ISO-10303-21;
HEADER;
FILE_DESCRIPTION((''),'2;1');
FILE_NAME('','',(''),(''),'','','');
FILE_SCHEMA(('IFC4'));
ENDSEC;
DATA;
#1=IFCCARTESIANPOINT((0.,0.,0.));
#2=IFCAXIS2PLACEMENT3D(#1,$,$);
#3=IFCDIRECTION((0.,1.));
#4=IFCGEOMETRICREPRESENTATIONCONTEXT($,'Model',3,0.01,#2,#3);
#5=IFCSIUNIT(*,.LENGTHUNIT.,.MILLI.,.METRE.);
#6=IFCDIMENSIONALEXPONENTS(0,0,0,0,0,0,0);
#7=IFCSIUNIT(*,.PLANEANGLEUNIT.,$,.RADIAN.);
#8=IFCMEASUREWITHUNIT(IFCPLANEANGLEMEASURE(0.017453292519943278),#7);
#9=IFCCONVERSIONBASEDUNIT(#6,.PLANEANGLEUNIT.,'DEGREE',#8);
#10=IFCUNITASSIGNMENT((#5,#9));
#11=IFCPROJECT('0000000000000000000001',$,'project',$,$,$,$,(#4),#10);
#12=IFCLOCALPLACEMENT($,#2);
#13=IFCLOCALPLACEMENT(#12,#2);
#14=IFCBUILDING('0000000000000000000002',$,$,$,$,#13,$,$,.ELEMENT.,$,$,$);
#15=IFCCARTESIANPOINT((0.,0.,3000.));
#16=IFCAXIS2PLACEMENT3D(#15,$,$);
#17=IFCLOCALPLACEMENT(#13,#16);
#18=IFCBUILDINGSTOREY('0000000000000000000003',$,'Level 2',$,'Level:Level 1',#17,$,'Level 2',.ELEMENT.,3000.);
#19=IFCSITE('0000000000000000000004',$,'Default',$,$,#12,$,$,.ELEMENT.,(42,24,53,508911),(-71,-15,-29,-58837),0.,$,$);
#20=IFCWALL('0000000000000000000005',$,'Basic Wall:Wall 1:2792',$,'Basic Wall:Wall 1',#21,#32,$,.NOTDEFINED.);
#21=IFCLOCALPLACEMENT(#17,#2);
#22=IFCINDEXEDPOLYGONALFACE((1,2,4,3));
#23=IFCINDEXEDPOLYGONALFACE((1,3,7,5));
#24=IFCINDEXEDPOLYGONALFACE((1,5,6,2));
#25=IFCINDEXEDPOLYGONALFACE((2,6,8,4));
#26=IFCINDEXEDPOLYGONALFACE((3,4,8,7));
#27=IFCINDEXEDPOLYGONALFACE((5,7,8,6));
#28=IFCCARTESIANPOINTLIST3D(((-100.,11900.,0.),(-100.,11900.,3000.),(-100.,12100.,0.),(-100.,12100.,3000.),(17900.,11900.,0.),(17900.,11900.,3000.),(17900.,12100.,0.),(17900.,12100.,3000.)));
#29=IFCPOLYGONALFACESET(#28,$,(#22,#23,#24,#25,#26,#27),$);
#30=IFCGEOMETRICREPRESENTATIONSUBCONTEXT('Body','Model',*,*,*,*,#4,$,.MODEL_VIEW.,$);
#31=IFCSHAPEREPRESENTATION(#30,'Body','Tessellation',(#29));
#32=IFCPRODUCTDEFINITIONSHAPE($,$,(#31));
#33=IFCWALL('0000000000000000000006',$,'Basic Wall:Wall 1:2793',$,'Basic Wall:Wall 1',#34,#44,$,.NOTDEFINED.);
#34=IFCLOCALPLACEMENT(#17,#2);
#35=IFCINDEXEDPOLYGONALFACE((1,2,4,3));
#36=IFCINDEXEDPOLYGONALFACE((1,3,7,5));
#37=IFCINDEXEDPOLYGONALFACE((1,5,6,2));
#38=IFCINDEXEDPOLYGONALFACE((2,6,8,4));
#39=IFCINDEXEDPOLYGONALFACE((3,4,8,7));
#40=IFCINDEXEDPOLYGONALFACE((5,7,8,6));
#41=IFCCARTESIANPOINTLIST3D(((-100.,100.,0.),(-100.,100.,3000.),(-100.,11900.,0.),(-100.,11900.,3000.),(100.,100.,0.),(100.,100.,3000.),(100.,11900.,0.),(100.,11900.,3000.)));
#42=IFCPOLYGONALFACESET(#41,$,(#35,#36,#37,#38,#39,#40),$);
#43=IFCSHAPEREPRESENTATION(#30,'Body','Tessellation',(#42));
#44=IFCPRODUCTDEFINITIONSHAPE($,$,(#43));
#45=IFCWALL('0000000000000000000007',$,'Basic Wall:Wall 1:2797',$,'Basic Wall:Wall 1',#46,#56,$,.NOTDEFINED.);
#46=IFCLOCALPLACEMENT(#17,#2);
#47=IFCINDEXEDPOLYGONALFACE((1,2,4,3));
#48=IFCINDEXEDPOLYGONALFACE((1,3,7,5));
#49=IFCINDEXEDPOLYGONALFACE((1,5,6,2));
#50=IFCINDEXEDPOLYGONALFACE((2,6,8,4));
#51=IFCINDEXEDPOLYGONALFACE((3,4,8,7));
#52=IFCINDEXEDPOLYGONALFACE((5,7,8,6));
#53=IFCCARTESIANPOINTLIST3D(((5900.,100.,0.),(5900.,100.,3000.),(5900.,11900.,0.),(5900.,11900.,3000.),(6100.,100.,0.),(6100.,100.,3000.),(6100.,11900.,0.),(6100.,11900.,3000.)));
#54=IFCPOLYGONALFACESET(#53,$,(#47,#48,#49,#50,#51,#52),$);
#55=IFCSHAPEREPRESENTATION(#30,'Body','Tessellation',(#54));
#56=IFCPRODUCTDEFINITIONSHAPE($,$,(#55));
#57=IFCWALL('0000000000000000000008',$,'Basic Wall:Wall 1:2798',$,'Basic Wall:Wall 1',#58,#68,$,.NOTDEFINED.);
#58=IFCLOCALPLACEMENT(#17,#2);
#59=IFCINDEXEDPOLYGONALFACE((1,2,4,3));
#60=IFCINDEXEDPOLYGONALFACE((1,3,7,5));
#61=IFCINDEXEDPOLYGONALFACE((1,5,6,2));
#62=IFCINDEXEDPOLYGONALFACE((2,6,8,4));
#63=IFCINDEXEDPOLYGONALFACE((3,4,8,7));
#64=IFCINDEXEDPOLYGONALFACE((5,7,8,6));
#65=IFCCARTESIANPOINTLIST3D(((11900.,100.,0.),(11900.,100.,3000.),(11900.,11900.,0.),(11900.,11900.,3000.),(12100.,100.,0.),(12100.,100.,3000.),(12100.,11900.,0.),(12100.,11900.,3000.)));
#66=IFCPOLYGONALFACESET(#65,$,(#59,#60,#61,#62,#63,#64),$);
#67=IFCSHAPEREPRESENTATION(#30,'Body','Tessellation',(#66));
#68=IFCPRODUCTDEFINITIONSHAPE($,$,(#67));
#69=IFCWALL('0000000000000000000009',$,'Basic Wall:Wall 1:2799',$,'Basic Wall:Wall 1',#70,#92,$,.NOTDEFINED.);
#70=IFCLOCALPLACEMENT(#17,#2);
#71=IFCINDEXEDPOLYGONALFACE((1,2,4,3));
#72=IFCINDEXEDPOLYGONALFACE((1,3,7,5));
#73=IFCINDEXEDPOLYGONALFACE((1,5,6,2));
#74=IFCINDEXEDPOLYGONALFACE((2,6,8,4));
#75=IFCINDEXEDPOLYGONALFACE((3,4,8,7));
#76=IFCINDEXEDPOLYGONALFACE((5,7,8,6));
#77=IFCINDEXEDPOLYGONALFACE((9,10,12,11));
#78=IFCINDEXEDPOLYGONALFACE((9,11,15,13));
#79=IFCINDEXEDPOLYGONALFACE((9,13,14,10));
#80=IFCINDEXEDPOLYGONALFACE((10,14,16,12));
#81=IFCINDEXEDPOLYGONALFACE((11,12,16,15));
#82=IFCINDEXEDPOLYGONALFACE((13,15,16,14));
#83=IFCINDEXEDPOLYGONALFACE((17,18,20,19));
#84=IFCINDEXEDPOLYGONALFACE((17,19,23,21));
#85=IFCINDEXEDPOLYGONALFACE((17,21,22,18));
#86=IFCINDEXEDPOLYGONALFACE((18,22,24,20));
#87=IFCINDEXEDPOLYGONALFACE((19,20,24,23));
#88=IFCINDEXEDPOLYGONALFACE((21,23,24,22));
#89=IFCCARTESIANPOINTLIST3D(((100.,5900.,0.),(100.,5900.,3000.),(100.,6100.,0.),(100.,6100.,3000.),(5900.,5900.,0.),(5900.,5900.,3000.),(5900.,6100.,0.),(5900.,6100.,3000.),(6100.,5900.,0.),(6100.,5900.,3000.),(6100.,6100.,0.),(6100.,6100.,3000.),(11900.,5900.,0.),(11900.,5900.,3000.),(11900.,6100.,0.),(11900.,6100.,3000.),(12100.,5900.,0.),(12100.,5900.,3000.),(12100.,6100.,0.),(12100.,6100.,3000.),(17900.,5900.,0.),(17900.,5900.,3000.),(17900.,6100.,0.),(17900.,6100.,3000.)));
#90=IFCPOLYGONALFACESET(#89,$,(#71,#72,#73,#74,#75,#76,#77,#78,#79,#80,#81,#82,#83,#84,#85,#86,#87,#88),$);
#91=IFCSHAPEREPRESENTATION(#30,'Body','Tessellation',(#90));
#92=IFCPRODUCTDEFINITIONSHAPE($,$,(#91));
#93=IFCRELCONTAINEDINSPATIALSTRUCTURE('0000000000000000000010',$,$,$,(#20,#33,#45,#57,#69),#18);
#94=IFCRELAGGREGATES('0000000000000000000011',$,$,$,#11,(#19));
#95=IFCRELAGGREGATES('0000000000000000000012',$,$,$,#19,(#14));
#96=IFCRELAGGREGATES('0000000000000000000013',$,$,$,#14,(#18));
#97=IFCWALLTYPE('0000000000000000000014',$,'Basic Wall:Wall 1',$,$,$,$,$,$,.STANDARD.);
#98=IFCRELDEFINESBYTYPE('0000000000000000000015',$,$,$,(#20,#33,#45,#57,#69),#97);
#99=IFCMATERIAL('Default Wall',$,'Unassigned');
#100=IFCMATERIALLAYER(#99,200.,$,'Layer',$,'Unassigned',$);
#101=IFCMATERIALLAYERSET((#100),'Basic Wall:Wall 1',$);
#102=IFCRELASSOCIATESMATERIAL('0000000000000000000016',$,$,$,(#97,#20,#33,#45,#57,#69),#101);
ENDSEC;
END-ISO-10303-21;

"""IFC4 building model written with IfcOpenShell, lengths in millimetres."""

from ifc_helpers import new_model, entity, si_unit, converted_unit, direction, frame, frame_2d, origin, origin_2d_with_axis, place, context, subcontext, project, spatial, rectangle, extrude, material, layer, layer_set, layer_usage, type_object, element, save


model = new_model("IFC4")

# Units and contexts
model_context = context("Model", 3, precision=0.01, world=origin(), true_north=direction((0.0, 1.0)))
body_context = subcontext(model_context, "Body", "Model", "MODEL_VIEW")
ifc_project = project(units=[si_unit("LENGTHUNIT", "METRE", prefix="MILLI"), converted_unit("PLANEANGLEUNIT", "DEGREE", entity("IfcPlaneAngleMeasure", 0.017453292519943278), si_unit("PLANEANGLEUNIT", "RADIAN"), dimensions=[0, 0, 0, 0, 0, 0, 0])], contexts=[model_context])

# Site, building, storey
site_placement = place(None, origin())
site = spatial("IfcSite", under=ifc_project, at=site_placement, Name="Default", CompositionType="ELEMENT", RefLatitude=(42, 24, 53, 508911), RefLongitude=(-71, -15, -29, -58837), RefElevation=0.0)
building_placement = place(site_placement, origin())
building = spatial("IfcBuilding", under=site, at=building_placement, CompositionType="ELEMENT")
storey_placement = place(building_placement, frame((0.0, 0.0, 3000.0)))
storey = spatial("IfcBuildingStorey", under=building, at=storey_placement, Name="Level 2", ObjectType="Level:Level 1", LongName="Level 2", CompositionType="ELEMENT", Elevation=3000.0)

# Walls
ifc_material_1 = material(Name="Default Wall", Category="Unassigned")
ifc_layer_1 = layer(ifc_material_1, 200.0, Name="Layer", Category="Unassigned")
ifc_layer_set_1 = layer_set([ifc_layer_1], Name="Basic Wall:Wall 1")
wall_type = type_object("IfcWallType", Name="Basic Wall:Wall 1", PredefinedType="STANDARD", material=ifc_layer_set_1)
ifc_layer_usage_1 = layer_usage(ifc_layer_set_1, "AXIS2", "NEGATIVE", 100.0)
wall_1_placement = place(storey_placement, frame((17900.0, 12000.0, 0.0), z_axis=(0.0, 0.0, 1.0), x_axis=(-1.0, 0.0, 0.0)))
element("IfcWall", 1, at=wall_1_placement, inside=storey, type_object=wall_type, material=ifc_layer_usage_1, Name="Basic Wall:Wall 1:2792", ObjectType="Basic Wall:Wall 1", PredefinedType="NOTDEFINED", context=body_context, shape_type="SweptSolid", body=[
    extrude(rectangle(XDim=18000.0, YDim=200.0, at=frame_2d((9000.0, 0.0), x_axis=(-1.0, 0.0))), origin(), (0.0, 0.0, 1.0), 3000.0),
])
ifc_layer_usage_2 = layer_usage(ifc_layer_set_1, "AXIS2", "NEGATIVE", 100.0)
wall_2_placement = place(storey_placement, frame((0.0, 11900.0, 0.0), z_axis=(0.0, 0.0, 1.0), x_axis=(0.0, -1.0, 0.0)))
element("IfcWall", 2, at=wall_2_placement, inside=storey, type_object=wall_type, material=ifc_layer_usage_2, Name="Basic Wall:Wall 1:2793", ObjectType="Basic Wall:Wall 1", PredefinedType="NOTDEFINED", context=body_context, shape_type="SweptSolid", body=[
    extrude(rectangle(XDim=11800.0, YDim=200.0, at=frame_2d((5900.0, 0.0), x_axis=(-1.0, 0.0))), origin(), (0.0, 0.0, 1.0), 3000.0),
])
ifc_layer_usage_3 = layer_usage(ifc_layer_set_1, "AXIS2", "NEGATIVE", 100.0)
wall_3_placement = place(storey_placement, frame((6000.0, 100.0, 0.0), z_axis=(0.0, 0.0, 1.0), x_axis=(0.0, 1.0, 0.0)))
element("IfcWall", 3, at=wall_3_placement, inside=storey, type_object=wall_type, material=ifc_layer_usage_3, Name="Basic Wall:Wall 1:2797", ObjectType="Basic Wall:Wall 1", PredefinedType="NOTDEFINED", context=body_context, shape_type="SweptSolid", body=[
    extrude(rectangle(XDim=11800.0, YDim=200.0, at=frame_2d((5900.0, 0.0), x_axis=(-1.0, 0.0))), origin(), (0.0, 0.0, 1.0), 3000.0),
])
ifc_layer_usage_4 = layer_usage(ifc_layer_set_1, "AXIS2", "NEGATIVE", 100.0)
wall_4_placement = place(storey_placement, frame((12000.0, 100.0, 0.0), z_axis=(0.0, 0.0, 1.0), x_axis=(0.0, 1.0, 0.0)))
element("IfcWall", 4, at=wall_4_placement, inside=storey, type_object=wall_type, material=ifc_layer_usage_4, Name="Basic Wall:Wall 1:2798", ObjectType="Basic Wall:Wall 1", PredefinedType="NOTDEFINED", context=body_context, shape_type="SweptSolid", body=[
    extrude(rectangle(XDim=11800.0, YDim=200.0, at=frame_2d((5900.0, 0.0), x_axis=(-1.0, 0.0))), origin(), (0.0, 0.0, 1.0), 3000.0),
])

# Wall, openings
ifc_layer_usage_5 = layer_usage(ifc_layer_set_1, "AXIS2", "NEGATIVE", 100.0)
wall_5_placement = place(storey_placement, frame((100.0, 6000.0, 0.0)))
wall_5 = element("IfcWall", 5, at=wall_5_placement, inside=storey, type_object=wall_type, material=ifc_layer_usage_5, Name="Basic Wall:Wall 1:2799", ObjectType="Basic Wall:Wall 1", PredefinedType="NOTDEFINED", context=body_context, shape_type="SweptSolid", body=[
    extrude(rectangle(XDim=17800.0, YDim=200.0, at=frame_2d((8900.0, 0.0), x_axis=(-1.0, 0.0))), origin(), (0.0, 0.0, 1.0), 3000.0),
])
opening_1_placement = place(storey_placement, frame((100.0, 6000.0, 0.0)))
element("IfcOpeningElement", 6, at=opening_1_placement, cuts=wall_5, PredefinedType="OPENING", context=body_context, shape_type="SweptSolid", body=[
    extrude(rectangle(XDim=3000.0, YDim=200.0, at=origin_2d_with_axis()), frame((11800.0, 0.0, 1500.0), z_axis=(1.0, 0.0, 0.0), x_axis=(0.0, 0.0, -1.0)), (0.0, 0.0, 1.0), 200.0),
])
opening_2_placement = place(storey_placement, frame((100.0, 6000.0, 0.0)))
element("IfcOpeningElement", 7, at=opening_2_placement, cuts=wall_5, PredefinedType="OPENING", context=body_context, shape_type="SweptSolid", body=[
    extrude(rectangle(XDim=3000.0, YDim=200.0, at=origin_2d_with_axis()), frame((5800.0, 0.0, 1500.0), z_axis=(1.0, 0.0, 0.0), x_axis=(0.0, 0.0, -1.0)), (0.0, 0.0, 1.0), 200.0),
])

save(model, "model.ifc")
